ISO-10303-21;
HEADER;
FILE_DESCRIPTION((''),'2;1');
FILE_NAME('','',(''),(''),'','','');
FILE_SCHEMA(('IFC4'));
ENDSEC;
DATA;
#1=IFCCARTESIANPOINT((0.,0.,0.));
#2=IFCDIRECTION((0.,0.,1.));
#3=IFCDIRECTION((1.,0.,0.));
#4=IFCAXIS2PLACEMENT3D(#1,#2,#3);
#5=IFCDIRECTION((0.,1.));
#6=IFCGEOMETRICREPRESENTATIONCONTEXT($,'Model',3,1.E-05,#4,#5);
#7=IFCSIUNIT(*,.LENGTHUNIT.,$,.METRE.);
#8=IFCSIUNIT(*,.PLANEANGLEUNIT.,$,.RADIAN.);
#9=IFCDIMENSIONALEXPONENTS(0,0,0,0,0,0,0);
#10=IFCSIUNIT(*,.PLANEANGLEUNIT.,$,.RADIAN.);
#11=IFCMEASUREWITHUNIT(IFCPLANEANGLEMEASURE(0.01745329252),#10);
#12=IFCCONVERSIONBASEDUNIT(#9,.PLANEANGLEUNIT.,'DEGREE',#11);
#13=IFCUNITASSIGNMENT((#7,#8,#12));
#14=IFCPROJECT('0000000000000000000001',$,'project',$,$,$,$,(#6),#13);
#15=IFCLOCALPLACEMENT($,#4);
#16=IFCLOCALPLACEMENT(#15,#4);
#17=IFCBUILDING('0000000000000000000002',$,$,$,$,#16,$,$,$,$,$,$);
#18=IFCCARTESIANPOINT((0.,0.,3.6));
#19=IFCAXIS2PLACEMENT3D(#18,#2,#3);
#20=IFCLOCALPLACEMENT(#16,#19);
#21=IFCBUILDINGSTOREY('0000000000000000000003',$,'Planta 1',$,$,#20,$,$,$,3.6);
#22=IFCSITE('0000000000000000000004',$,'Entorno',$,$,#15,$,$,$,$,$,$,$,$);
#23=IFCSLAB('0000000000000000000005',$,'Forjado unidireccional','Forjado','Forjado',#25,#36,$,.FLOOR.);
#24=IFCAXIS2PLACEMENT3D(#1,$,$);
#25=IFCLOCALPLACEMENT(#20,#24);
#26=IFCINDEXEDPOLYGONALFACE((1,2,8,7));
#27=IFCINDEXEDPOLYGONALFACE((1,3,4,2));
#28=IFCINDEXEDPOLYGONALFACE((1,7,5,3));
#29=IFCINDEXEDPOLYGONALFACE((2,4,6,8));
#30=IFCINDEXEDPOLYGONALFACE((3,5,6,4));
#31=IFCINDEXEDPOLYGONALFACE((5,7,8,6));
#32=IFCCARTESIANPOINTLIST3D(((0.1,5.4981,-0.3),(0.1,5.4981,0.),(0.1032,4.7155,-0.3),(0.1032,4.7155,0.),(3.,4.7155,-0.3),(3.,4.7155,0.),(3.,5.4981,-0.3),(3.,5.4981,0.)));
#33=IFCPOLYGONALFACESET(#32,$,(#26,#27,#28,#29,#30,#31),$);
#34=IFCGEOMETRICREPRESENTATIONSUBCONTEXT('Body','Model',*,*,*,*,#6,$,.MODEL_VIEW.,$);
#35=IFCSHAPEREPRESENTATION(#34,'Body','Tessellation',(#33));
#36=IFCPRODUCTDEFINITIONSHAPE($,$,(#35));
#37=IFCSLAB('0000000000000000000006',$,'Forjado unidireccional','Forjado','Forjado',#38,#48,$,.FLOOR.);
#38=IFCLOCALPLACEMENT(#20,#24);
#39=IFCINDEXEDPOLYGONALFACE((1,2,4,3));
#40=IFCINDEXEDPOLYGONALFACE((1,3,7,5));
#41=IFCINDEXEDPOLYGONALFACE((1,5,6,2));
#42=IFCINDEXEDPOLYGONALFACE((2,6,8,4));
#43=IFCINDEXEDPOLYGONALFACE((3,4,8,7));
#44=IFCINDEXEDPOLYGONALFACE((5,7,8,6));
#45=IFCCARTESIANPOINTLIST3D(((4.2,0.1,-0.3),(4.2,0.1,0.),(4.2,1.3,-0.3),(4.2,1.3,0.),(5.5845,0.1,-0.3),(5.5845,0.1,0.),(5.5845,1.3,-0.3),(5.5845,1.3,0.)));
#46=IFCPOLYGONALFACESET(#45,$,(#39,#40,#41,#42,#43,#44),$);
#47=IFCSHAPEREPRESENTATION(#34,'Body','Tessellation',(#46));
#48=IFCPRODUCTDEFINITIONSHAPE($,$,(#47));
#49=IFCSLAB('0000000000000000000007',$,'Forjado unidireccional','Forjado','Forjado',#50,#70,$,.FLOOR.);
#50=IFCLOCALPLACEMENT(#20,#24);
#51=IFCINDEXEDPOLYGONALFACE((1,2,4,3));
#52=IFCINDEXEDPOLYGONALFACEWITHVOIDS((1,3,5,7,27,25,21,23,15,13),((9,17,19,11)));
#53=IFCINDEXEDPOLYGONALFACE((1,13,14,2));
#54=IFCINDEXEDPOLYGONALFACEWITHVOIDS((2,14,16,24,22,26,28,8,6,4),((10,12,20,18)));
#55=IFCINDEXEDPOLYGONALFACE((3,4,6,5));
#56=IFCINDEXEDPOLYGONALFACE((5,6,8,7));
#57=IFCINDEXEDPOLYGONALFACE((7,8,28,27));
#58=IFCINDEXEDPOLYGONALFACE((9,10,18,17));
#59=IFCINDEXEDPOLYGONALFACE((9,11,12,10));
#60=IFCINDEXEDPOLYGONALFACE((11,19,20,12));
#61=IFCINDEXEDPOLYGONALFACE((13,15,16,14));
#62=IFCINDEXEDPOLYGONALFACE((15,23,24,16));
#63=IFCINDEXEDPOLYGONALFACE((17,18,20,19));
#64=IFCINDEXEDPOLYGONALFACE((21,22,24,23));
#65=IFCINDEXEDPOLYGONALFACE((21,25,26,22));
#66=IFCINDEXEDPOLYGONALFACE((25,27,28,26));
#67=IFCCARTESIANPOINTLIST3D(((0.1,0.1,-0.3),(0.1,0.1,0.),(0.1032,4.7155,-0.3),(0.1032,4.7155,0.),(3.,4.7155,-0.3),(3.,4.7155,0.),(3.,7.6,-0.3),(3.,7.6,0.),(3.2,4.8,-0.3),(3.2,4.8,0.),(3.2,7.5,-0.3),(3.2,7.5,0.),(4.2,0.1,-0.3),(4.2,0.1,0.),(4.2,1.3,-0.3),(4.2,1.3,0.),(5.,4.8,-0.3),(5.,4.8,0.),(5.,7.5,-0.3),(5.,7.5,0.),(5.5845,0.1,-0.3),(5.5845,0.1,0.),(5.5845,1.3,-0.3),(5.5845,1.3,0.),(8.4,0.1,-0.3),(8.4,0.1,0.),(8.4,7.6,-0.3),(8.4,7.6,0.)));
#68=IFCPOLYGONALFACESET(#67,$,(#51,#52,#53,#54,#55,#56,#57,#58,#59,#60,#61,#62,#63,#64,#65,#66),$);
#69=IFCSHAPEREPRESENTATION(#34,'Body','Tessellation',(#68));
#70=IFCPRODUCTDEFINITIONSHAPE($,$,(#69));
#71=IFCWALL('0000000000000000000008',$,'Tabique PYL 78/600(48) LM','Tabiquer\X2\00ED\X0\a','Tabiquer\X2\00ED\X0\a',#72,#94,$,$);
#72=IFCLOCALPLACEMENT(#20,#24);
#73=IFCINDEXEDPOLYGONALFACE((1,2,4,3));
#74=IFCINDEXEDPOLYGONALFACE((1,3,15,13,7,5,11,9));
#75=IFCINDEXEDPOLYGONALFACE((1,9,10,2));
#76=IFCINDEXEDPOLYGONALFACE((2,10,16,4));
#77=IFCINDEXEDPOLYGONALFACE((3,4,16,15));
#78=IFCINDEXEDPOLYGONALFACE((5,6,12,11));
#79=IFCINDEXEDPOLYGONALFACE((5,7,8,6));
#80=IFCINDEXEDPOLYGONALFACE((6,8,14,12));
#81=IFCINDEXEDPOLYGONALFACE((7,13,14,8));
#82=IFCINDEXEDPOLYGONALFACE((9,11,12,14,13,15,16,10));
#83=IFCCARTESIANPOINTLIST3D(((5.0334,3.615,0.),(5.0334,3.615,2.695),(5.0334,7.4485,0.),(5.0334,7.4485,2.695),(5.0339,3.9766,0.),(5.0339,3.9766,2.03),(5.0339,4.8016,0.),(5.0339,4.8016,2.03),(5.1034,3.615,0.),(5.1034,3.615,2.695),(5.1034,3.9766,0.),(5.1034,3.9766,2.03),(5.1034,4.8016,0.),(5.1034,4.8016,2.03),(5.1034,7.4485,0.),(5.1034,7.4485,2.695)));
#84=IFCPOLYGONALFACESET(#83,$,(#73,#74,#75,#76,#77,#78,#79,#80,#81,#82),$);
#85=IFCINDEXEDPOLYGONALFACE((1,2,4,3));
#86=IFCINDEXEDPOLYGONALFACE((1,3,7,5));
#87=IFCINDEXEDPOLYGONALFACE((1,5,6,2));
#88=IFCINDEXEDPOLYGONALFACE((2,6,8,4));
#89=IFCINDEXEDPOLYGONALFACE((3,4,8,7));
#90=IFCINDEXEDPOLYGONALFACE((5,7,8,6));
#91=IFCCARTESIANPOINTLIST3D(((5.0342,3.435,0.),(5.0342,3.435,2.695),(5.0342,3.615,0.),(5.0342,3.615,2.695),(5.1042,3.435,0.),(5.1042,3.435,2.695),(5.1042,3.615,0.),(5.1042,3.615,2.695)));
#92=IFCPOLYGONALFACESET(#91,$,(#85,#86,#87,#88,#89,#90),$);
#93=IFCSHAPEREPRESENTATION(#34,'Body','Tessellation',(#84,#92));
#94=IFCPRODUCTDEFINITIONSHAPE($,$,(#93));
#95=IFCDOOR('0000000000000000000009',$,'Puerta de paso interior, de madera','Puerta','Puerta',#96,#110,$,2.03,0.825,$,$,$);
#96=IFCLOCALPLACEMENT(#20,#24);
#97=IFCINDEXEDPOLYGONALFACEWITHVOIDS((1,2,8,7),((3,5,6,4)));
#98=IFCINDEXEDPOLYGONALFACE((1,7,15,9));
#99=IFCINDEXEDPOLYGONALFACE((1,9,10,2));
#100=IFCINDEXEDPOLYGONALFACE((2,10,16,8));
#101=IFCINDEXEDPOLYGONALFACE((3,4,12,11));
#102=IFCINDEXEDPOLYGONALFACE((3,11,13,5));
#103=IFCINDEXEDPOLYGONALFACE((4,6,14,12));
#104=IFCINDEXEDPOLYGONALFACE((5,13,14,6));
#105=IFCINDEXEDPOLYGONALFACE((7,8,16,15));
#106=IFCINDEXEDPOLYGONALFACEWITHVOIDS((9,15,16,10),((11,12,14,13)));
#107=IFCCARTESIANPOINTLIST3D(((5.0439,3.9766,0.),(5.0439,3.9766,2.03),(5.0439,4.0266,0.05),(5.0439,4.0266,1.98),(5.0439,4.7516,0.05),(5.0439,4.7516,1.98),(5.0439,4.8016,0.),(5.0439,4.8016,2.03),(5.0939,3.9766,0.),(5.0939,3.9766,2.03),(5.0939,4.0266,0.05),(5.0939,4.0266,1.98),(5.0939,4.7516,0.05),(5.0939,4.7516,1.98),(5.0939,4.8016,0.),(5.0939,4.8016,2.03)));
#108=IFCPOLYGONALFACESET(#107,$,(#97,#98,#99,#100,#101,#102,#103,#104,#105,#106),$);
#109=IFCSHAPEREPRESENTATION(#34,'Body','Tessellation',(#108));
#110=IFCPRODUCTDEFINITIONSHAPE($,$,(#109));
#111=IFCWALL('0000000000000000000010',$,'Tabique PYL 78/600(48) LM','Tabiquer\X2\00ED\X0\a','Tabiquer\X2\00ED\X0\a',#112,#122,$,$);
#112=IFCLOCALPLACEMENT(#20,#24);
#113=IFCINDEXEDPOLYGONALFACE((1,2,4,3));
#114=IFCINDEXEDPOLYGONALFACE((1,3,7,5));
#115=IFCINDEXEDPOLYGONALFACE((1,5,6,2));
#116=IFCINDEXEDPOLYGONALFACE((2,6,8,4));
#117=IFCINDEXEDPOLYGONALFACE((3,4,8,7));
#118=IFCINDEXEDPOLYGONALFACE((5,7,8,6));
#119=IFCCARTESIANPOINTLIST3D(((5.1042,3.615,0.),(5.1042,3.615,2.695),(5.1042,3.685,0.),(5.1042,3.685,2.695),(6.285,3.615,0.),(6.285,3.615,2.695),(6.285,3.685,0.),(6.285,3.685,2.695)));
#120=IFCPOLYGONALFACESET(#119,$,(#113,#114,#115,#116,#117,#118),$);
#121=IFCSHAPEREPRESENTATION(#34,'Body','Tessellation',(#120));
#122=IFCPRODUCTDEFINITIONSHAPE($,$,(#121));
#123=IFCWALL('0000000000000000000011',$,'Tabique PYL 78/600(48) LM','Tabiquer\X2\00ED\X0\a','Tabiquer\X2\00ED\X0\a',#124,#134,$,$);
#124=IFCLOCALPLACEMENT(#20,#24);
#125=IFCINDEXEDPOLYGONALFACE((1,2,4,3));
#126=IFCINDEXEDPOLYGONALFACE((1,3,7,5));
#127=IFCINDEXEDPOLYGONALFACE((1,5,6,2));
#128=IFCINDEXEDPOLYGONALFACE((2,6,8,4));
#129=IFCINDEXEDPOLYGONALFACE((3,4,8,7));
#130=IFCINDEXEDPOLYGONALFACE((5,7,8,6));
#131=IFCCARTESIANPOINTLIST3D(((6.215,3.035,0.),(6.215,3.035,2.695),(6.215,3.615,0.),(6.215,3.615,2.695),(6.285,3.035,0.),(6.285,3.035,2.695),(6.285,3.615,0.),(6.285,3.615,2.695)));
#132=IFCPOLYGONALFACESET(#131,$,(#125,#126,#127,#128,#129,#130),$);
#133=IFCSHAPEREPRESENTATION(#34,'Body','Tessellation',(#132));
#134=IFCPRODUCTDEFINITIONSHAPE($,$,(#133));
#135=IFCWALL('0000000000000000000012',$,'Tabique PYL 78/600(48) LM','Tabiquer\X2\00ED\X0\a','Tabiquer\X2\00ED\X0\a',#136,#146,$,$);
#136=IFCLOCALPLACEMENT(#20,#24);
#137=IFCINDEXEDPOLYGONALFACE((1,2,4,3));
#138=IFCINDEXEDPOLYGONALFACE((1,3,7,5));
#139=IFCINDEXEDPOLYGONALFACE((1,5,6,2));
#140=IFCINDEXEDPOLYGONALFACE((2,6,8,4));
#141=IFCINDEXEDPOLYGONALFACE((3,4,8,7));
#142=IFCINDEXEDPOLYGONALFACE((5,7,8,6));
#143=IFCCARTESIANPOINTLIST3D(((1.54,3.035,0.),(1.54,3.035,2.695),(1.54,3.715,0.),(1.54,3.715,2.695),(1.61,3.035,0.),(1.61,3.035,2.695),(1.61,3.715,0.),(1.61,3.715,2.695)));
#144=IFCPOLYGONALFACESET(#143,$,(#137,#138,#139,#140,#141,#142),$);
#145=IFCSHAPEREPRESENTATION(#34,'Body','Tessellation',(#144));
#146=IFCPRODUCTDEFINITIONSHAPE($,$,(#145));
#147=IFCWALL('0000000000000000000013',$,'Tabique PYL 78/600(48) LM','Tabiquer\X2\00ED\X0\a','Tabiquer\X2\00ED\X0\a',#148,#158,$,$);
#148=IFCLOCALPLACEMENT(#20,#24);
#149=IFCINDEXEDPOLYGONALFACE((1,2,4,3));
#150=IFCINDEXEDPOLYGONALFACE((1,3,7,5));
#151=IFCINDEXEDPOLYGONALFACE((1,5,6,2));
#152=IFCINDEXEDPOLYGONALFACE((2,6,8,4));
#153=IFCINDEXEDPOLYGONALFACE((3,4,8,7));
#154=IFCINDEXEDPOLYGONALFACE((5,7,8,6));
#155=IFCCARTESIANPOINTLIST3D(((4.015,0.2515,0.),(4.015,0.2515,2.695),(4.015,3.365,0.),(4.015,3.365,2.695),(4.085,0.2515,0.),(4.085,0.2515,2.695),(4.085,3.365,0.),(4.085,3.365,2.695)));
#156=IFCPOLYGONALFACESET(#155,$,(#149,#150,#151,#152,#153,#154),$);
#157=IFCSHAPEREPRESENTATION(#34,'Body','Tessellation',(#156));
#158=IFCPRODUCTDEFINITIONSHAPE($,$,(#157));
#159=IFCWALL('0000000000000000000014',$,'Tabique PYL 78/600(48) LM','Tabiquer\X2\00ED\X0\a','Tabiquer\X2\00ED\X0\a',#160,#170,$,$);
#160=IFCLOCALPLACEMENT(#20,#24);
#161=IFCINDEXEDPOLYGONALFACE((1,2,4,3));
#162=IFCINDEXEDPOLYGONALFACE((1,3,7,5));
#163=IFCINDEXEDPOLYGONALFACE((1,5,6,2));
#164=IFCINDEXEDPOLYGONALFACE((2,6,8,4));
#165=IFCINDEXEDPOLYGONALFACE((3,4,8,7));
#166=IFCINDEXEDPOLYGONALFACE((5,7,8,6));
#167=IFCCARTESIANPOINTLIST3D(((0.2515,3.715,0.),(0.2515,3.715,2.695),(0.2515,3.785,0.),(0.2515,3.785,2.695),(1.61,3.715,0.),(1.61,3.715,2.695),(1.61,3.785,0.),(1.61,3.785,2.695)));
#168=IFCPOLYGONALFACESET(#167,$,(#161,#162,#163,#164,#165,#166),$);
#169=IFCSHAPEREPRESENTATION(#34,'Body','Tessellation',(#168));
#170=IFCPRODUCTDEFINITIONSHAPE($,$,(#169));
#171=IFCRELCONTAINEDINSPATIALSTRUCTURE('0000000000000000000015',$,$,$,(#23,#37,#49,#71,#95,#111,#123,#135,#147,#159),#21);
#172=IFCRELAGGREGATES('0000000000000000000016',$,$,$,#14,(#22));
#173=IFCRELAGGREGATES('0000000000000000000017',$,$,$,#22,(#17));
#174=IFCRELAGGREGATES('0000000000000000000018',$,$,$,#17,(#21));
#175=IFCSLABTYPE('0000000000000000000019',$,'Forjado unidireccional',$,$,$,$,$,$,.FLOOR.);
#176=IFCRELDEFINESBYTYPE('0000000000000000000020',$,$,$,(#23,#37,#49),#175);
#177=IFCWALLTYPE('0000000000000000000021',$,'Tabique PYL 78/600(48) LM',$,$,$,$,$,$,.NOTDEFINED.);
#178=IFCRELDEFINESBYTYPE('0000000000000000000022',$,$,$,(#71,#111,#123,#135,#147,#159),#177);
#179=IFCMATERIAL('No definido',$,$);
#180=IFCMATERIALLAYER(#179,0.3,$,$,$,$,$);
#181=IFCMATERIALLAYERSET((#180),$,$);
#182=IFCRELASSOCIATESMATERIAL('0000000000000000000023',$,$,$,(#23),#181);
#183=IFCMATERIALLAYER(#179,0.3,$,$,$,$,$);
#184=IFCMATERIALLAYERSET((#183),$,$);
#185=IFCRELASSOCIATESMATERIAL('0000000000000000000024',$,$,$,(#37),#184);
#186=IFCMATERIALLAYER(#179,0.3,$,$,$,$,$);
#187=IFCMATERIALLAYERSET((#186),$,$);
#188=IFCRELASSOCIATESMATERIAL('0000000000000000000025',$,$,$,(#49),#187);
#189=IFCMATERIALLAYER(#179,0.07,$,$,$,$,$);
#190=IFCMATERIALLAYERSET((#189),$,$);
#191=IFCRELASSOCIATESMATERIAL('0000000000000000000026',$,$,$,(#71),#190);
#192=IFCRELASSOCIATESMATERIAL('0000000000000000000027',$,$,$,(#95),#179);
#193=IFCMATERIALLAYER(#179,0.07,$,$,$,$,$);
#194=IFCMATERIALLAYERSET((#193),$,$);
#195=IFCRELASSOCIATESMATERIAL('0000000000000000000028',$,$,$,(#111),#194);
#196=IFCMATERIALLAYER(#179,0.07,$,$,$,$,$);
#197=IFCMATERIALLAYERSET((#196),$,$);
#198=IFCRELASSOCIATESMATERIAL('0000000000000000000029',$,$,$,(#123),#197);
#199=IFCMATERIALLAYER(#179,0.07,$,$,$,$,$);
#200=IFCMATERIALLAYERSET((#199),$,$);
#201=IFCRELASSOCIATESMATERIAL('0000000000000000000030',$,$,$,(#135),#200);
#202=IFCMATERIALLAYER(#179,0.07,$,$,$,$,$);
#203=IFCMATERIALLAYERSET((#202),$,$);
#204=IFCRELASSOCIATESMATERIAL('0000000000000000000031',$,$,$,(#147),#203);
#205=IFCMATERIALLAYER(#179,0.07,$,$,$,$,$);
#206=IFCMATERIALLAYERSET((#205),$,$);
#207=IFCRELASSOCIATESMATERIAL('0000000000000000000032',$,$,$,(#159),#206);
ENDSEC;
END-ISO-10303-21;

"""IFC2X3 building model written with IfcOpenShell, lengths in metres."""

from ifc_helpers import new_model, entity, si_unit, converted_unit, direction, frame, origin_with_axes, origin_2d_with_axis, place, context, subcontext, project, spatial, polyline, rectangle, hollow_rectangle, outline, extrude, shape, material, layer, layer_set, layer_usage, type_object, element, fill, save


model = new_model("IFC2X3")

# Units and contexts
model_context = context("Model", 3, precision=1e-05, world=origin_with_axes(), true_north=direction((0.0, 1.0)))
body_context = subcontext(model_context, "Body", "Model", "MODEL_VIEW")
footprint_context = subcontext(model_context, "FootPrint", "Model", "MODEL_VIEW")
ifc_project = project(units=[si_unit("LENGTHUNIT", "METRE"), si_unit("PLANEANGLEUNIT", "RADIAN"), converted_unit("PLANEANGLEUNIT", "DEGREE", entity("IfcPlaneAngleMeasure", 0.01745329252), si_unit("PLANEANGLEUNIT", "RADIAN"), dimensions=[0, 0, 0, 0, 0, 0, 0])], contexts=[model_context])

# Site, building, storey
site_placement = place(None, origin_with_axes())
site = spatial("IfcSite", under=ifc_project, at=site_placement, Name="Entorno")
building_placement = place(site_placement, origin_with_axes())
building = spatial("IfcBuilding", under=site, at=building_placement)
storey_placement = place(building_placement, frame((0.0, 0.0, 3.6), z_axis=(0.0, 0.0, 1.0), x_axis=(1.0, 0.0, 0.0)))
storey = spatial("IfcBuildingStorey", under=building, at=storey_placement, Name="Planta 1", Elevation=3.6)

# Slabs
ifc_material = material(Name="No definido")
ifc_layer_1 = layer(ifc_material, 0.3)
ifc_layer_set_1 = layer_set([ifc_layer_1])
ifc_layer_usage_1 = layer_usage(ifc_layer_set_1, "AXIS3", "POSITIVE", 0.0)
slab_type = type_object("IfcSlabType", Name="Forjado unidireccional", PredefinedType="FLOOR")
slab_1_placement = place(storey_placement, frame((3.0, 5.4981, -0.3), z_axis=(0.0, 0.0, 1.0), x_axis=(1.0, 0.0, 0.0)))
element("IfcSlab", 1, at=slab_1_placement, inside=storey, type_object=slab_type, material=ifc_layer_usage_1, Name="Forjado unidireccional", Description="Forjado", ObjectType="Forjado", PredefinedType="FLOOR", context=body_context, shape_type="SweptSolid", body=[
    extrude(outline(polyline([(0.0, 0.0), (-2.9, 0.0), (-2.8968, -0.7826), (0.0, -0.7826), (0.0, 0.0)])), origin_with_axes(), (0.0, 0.0, 1.0), 0.3),
])
ifc_layer_2 = layer(ifc_material, 0.3)
ifc_layer_set_2 = layer_set([ifc_layer_2])
ifc_layer_usage_2 = layer_usage(ifc_layer_set_2, "AXIS3", "POSITIVE", 0.0)
slab_2_placement = place(storey_placement, frame((5.5845, 0.1, -0.3), z_axis=(0.0, 0.0, 1.0), x_axis=(1.0, 0.0, 0.0)))
element("IfcSlab", 2, at=slab_2_placement, inside=storey, type_object=slab_type, material=ifc_layer_usage_2, Name="Forjado unidireccional", Description="Forjado", ObjectType="Forjado", PredefinedType="FLOOR", context=body_context, shape_type="SweptSolid", body=[
    extrude(outline(polyline([(0.0, 0.0), (0.0, 1.2), (-1.3845, 1.2), (-1.3845, 0.0), (0.0, 0.0)])), origin_with_axes(), (0.0, 0.0, 1.0), 0.3),
])

# Slab, opening
ifc_layer_3 = layer(ifc_material, 0.3)
ifc_layer_set_3 = layer_set([ifc_layer_3])
ifc_layer_usage_3 = layer_usage(ifc_layer_set_3, "AXIS3", "POSITIVE", 0.0)
slab_3_placement = place(storey_placement, frame((5.5845, 0.1, -0.3), z_axis=(0.0, 0.0, 1.0), x_axis=(1.0, 0.0, 0.0)))
slab_3 = element("IfcSlab", 3, at=slab_3_placement, inside=storey, type_object=slab_type, material=ifc_layer_usage_3, Name="Forjado unidireccional", Description="Forjado", ObjectType="Forjado", PredefinedType="FLOOR", context=body_context, shape_type="SweptSolid", body=[
    extrude(outline(polyline([(0.0, 0.0), (2.8155, 0.0), (2.8155, 7.5), (-2.5845, 7.5), (-2.5845, 4.6155), (-5.4813, 4.6155), (-5.4845, 0.0), (-1.3845, 0.0), (-1.3845, 1.2), (0.0, 1.2), (0.0, 0.0)])), origin_with_axes(), (0.0, 0.0, 1.0), 0.3),
])
opening_1_placement = place(slab_3_placement, frame((-2.3845, 4.7, -0.01), z_axis=(0.0, 0.0, 1.0), x_axis=(1.0, 0.0, 0.0)))
element("IfcOpeningElement", 4, at=opening_1_placement, cuts=slab_3, ObjectType="No definido", context=body_context, shape_type="SweptSolid", body=[
    extrude(outline(polyline([(0.0, 0.0), (1.8, 0.0), (1.8, 2.7), (0.0, 2.7), (0.0, 0.0)])), origin_with_axes(), (0.0, 0.0, 1.0), 0.32),
])

# Wall, opening, door
ifc_layer_4 = layer(ifc_material, 0.07)
ifc_layer_set_4 = layer_set([ifc_layer_4])
ifc_layer_usage_4 = layer_usage(ifc_layer_set_4, "AXIS2", "POSITIVE", -0.035)
wall_type = type_object("IfcWallType", Name="Tabique PYL 78/600(48) LM")
wall_1_placement = place(storey_placement, frame((5.0692, 7.6, 0.0), z_axis=(0.0, 0.0, 1.0), x_axis=(0.0, -1.0, 0.0)))
wall_1 = element("IfcWall", 5, at=wall_1_placement, inside=storey, type_object=wall_type, material=ifc_layer_usage_4, Name="Tabique PYL 78/600(48) LM", Description="Tabiquería", ObjectType="Tabiquería", context=body_context, shape_type="SolidModel", body=[
    extrude(outline(polyline([(-1.9167, -1.3475), (1.9167, -1.3475), (1.9167, 1.3475), (-1.9167, 1.3475), (-1.9167, -1.3475)])), frame((2.0682, 0.0342, 1.3475), z_axis=(0.0, -1.0, 0.0), x_axis=(1.0, 0.0, 0.0)), (0.0, 0.0, 1.0), 0.07),
    extrude(outline(polyline([(-0.09, -1.3475), (0.09, -1.3475), (0.09, 1.3475), (-0.09, 1.3475), (-0.09, -1.3475)])), frame((4.075, 0.035, 1.3475), z_axis=(0.0, -1.0, 0.0), x_axis=(1.0, 0.0, 0.0)), (0.0, 0.0, 1.0), 0.07),
])
opening_2_placement = place(wall_1_placement, frame((3.2109, -0.0003, 1.015), z_axis=(0.0, 0.0, 1.0), x_axis=(1.0, 0.0, 0.0)))
cartesian_point_1 = entity("IfcCartesianPoint", [-0.4125, -0.035])
opening_2 = element("IfcOpeningElement", 6, at=opening_2_placement, cuts=wall_1, ObjectType="No definido", shapes=[
    shape(body_context, "Body", "SweptSolid", [extrude(rectangle(XDim=2.03, YDim=0.825, at=origin_2d_with_axis()), frame((0.0, -0.035, 0.0), z_axis=(0.0, 1.0, 0.0), x_axis=(0.0, 0.0, 1.0)), (0.0, 0.0, 1.0), 0.07)]),
    shape(footprint_context, "FootPrint", "GeometricCurveSet", [entity("IfcGeometricCurveSet", [entity("IfcPolyline", [cartesian_point_1, entity("IfcCartesianPoint", [0.4125, -0.035]), entity("IfcCartesianPoint", [0.4125, 0.035]), entity("IfcCartesianPoint", [-0.4125, 0.035]), cartesian_point_1])])]),
])
door_1_placement = place(opening_2_placement, origin_with_axes())
door_1 = element("IfcDoor", 7, at=door_1_placement, inside=storey, material=ifc_material, Name="Puerta de paso interior, de madera", Description="Puerta", ObjectType="Puerta", OverallHeight=2.03, OverallWidth=0.825, context=body_context, shape_type="SweptSolid", body=[
    extrude(hollow_rectangle(XDim=0.825, YDim=2.03, WallThickness=0.05, InnerFilletRadius=0.0, OuterFilletRadius=0.0, at=origin_2d_with_axis()), frame((0.0, 0.025, 0.0), z_axis=(0.0, -1.0, 0.0), x_axis=(1.0, 0.0, 0.0)), (0.0, 0.0, 1.0), 0.05),
])
fill(opening_2, door_1)

# Walls
ifc_layer_5 = layer(ifc_material, 0.07)
ifc_layer_set_5 = layer_set([ifc_layer_5])
ifc_layer_usage_5 = layer_usage(ifc_layer_set_5, "AXIS2", "POSITIVE", -0.035)
wall_2_placement = place(storey_placement, frame((5.0692, 3.65, 0.0), z_axis=(0.0, 0.0, 1.0), x_axis=(1.0, 0.0, 0.0)))
element("IfcWall", 8, at=wall_2_placement, inside=storey, type_object=wall_type, material=ifc_layer_usage_5, Name="Tabique PYL 78/600(48) LM", Description="Tabiquería", ObjectType="Tabiquería", context=body_context, shape_type="SolidModel", body=[
    extrude(outline(polyline([(-0.5904, -1.3475), (0.5904, -1.3475), (0.5904, 1.3475), (-0.5904, 1.3475), (-0.5904, -1.3475)])), frame((0.6254, 0.035, 1.3475), z_axis=(0.0, -1.0, 0.0), x_axis=(1.0, 0.0, 0.0)), (0.0, 0.0, 1.0), 0.07),
])
ifc_layer_6 = layer(ifc_material, 0.07)
ifc_layer_set_6 = layer_set([ifc_layer_6])
ifc_layer_usage_6 = layer_usage(ifc_layer_set_6, "AXIS2", "POSITIVE", -0.035)
wall_3_placement = place(storey_placement, frame((6.25, 3.65, 0.0), z_axis=(0.0, 0.0, 1.0), x_axis=(0.0, -1.0, 0.0)))
element("IfcWall", 9, at=wall_3_placement, inside=storey, type_object=wall_type, material=ifc_layer_usage_6, Name="Tabique PYL 78/600(48) LM", Description="Tabiquería", ObjectType="Tabiquería", context=body_context, shape_type="SolidModel", body=[
    extrude(outline(polyline([(-0.29, -1.3475), (0.29, -1.3475), (0.29, 1.3475), (-0.29, 1.3475), (-0.29, -1.3475)])), frame((0.325, 0.035, 1.3475), z_axis=(0.0, -1.0, 0.0), x_axis=(1.0, 0.0, 0.0)), (0.0, 0.0, 1.0), 0.07),
])
ifc_layer_7 = layer(ifc_material, 0.07)
ifc_layer_set_7 = layer_set([ifc_layer_7])
ifc_layer_usage_7 = layer_usage(ifc_layer_set_7, "AXIS2", "POSITIVE", -0.035)
wall_4_placement = place(storey_placement, frame((1.575, 3.75, 0.0), z_axis=(0.0, 0.0, 1.0), x_axis=(0.0, -1.0, 0.0)))
element("IfcWall", 10, at=wall_4_placement, inside=storey, type_object=wall_type, material=ifc_layer_usage_7, Name="Tabique PYL 78/600(48) LM", Description="Tabiquería", ObjectType="Tabiquería", context=body_context, shape_type="SolidModel", body=[
    extrude(outline(polyline([(-0.34, -1.3475), (0.34, -1.3475), (0.34, 1.3475), (-0.34, 1.3475), (-0.34, -1.3475)])), frame((0.375, 0.035, 1.3475), z_axis=(0.0, -1.0, 0.0), x_axis=(1.0, 0.0, 0.0)), (0.0, 0.0, 1.0), 0.07),
])
ifc_layer_8 = layer(ifc_material, 0.07)
ifc_layer_set_8 = layer_set([ifc_layer_8])
ifc_layer_usage_8 = layer_usage(ifc_layer_set_8, "AXIS2", "POSITIVE", -0.035)
wall_5_placement = place(storey_placement, frame((4.05, 3.4, 0.0), z_axis=(0.0, 0.0, 1.0), x_axis=(0.0, -1.0, 0.0)))
element("IfcWall", 11, at=wall_5_placement, inside=storey, type_object=wall_type, material=ifc_layer_usage_8, Name="Tabique PYL 78/600(48) LM", Description="Tabiquería", ObjectType="Tabiquería", context=body_context, shape_type="SolidModel", body=[
    extrude(outline(polyline([(-1.5568, -1.3475), (1.5568, -1.3475), (1.5568, 1.3475), (-1.5568, 1.3475), (-1.5568, -1.3475)])), frame((1.5917, 0.035, 1.3475), z_axis=(0.0, -1.0, 0.0), x_axis=(1.0, 0.0, 0.0)), (0.0, 0.0, 1.0), 0.07),
])
ifc_layer_9 = layer(ifc_material, 0.07)
ifc_layer_set_9 = layer_set([ifc_layer_9])
ifc_layer_usage_9 = layer_usage(ifc_layer_set_9, "AXIS2", "POSITIVE", -0.035)
wall_6_placement = place(storey_placement, frame((1.575, 3.75, 0.0), z_axis=(0.0, 0.0, 1.0), x_axis=(-1.0, 0.0, 0.0)))
element("IfcWall", 12, at=wall_6_placement, inside=storey, type_object=wall_type, material=ifc_layer_usage_9, Name="Tabique PYL 78/600(48) LM", Description="Tabiquería", ObjectType="Tabiquería", context=body_context, shape_type="SolidModel", body=[
    extrude(outline(polyline([(-0.6793, -1.3475), (0.6793, -1.3475), (0.6793, 1.3475), (-0.6793, 1.3475), (-0.6793, -1.3475)])), frame((0.6442, 0.035, 1.3475), z_axis=(0.0, -1.0, 0.0), x_axis=(1.0, 0.0, 0.0)), (0.0, 0.0, 1.0), 0.07),
])

save(model, "model.ifc")
